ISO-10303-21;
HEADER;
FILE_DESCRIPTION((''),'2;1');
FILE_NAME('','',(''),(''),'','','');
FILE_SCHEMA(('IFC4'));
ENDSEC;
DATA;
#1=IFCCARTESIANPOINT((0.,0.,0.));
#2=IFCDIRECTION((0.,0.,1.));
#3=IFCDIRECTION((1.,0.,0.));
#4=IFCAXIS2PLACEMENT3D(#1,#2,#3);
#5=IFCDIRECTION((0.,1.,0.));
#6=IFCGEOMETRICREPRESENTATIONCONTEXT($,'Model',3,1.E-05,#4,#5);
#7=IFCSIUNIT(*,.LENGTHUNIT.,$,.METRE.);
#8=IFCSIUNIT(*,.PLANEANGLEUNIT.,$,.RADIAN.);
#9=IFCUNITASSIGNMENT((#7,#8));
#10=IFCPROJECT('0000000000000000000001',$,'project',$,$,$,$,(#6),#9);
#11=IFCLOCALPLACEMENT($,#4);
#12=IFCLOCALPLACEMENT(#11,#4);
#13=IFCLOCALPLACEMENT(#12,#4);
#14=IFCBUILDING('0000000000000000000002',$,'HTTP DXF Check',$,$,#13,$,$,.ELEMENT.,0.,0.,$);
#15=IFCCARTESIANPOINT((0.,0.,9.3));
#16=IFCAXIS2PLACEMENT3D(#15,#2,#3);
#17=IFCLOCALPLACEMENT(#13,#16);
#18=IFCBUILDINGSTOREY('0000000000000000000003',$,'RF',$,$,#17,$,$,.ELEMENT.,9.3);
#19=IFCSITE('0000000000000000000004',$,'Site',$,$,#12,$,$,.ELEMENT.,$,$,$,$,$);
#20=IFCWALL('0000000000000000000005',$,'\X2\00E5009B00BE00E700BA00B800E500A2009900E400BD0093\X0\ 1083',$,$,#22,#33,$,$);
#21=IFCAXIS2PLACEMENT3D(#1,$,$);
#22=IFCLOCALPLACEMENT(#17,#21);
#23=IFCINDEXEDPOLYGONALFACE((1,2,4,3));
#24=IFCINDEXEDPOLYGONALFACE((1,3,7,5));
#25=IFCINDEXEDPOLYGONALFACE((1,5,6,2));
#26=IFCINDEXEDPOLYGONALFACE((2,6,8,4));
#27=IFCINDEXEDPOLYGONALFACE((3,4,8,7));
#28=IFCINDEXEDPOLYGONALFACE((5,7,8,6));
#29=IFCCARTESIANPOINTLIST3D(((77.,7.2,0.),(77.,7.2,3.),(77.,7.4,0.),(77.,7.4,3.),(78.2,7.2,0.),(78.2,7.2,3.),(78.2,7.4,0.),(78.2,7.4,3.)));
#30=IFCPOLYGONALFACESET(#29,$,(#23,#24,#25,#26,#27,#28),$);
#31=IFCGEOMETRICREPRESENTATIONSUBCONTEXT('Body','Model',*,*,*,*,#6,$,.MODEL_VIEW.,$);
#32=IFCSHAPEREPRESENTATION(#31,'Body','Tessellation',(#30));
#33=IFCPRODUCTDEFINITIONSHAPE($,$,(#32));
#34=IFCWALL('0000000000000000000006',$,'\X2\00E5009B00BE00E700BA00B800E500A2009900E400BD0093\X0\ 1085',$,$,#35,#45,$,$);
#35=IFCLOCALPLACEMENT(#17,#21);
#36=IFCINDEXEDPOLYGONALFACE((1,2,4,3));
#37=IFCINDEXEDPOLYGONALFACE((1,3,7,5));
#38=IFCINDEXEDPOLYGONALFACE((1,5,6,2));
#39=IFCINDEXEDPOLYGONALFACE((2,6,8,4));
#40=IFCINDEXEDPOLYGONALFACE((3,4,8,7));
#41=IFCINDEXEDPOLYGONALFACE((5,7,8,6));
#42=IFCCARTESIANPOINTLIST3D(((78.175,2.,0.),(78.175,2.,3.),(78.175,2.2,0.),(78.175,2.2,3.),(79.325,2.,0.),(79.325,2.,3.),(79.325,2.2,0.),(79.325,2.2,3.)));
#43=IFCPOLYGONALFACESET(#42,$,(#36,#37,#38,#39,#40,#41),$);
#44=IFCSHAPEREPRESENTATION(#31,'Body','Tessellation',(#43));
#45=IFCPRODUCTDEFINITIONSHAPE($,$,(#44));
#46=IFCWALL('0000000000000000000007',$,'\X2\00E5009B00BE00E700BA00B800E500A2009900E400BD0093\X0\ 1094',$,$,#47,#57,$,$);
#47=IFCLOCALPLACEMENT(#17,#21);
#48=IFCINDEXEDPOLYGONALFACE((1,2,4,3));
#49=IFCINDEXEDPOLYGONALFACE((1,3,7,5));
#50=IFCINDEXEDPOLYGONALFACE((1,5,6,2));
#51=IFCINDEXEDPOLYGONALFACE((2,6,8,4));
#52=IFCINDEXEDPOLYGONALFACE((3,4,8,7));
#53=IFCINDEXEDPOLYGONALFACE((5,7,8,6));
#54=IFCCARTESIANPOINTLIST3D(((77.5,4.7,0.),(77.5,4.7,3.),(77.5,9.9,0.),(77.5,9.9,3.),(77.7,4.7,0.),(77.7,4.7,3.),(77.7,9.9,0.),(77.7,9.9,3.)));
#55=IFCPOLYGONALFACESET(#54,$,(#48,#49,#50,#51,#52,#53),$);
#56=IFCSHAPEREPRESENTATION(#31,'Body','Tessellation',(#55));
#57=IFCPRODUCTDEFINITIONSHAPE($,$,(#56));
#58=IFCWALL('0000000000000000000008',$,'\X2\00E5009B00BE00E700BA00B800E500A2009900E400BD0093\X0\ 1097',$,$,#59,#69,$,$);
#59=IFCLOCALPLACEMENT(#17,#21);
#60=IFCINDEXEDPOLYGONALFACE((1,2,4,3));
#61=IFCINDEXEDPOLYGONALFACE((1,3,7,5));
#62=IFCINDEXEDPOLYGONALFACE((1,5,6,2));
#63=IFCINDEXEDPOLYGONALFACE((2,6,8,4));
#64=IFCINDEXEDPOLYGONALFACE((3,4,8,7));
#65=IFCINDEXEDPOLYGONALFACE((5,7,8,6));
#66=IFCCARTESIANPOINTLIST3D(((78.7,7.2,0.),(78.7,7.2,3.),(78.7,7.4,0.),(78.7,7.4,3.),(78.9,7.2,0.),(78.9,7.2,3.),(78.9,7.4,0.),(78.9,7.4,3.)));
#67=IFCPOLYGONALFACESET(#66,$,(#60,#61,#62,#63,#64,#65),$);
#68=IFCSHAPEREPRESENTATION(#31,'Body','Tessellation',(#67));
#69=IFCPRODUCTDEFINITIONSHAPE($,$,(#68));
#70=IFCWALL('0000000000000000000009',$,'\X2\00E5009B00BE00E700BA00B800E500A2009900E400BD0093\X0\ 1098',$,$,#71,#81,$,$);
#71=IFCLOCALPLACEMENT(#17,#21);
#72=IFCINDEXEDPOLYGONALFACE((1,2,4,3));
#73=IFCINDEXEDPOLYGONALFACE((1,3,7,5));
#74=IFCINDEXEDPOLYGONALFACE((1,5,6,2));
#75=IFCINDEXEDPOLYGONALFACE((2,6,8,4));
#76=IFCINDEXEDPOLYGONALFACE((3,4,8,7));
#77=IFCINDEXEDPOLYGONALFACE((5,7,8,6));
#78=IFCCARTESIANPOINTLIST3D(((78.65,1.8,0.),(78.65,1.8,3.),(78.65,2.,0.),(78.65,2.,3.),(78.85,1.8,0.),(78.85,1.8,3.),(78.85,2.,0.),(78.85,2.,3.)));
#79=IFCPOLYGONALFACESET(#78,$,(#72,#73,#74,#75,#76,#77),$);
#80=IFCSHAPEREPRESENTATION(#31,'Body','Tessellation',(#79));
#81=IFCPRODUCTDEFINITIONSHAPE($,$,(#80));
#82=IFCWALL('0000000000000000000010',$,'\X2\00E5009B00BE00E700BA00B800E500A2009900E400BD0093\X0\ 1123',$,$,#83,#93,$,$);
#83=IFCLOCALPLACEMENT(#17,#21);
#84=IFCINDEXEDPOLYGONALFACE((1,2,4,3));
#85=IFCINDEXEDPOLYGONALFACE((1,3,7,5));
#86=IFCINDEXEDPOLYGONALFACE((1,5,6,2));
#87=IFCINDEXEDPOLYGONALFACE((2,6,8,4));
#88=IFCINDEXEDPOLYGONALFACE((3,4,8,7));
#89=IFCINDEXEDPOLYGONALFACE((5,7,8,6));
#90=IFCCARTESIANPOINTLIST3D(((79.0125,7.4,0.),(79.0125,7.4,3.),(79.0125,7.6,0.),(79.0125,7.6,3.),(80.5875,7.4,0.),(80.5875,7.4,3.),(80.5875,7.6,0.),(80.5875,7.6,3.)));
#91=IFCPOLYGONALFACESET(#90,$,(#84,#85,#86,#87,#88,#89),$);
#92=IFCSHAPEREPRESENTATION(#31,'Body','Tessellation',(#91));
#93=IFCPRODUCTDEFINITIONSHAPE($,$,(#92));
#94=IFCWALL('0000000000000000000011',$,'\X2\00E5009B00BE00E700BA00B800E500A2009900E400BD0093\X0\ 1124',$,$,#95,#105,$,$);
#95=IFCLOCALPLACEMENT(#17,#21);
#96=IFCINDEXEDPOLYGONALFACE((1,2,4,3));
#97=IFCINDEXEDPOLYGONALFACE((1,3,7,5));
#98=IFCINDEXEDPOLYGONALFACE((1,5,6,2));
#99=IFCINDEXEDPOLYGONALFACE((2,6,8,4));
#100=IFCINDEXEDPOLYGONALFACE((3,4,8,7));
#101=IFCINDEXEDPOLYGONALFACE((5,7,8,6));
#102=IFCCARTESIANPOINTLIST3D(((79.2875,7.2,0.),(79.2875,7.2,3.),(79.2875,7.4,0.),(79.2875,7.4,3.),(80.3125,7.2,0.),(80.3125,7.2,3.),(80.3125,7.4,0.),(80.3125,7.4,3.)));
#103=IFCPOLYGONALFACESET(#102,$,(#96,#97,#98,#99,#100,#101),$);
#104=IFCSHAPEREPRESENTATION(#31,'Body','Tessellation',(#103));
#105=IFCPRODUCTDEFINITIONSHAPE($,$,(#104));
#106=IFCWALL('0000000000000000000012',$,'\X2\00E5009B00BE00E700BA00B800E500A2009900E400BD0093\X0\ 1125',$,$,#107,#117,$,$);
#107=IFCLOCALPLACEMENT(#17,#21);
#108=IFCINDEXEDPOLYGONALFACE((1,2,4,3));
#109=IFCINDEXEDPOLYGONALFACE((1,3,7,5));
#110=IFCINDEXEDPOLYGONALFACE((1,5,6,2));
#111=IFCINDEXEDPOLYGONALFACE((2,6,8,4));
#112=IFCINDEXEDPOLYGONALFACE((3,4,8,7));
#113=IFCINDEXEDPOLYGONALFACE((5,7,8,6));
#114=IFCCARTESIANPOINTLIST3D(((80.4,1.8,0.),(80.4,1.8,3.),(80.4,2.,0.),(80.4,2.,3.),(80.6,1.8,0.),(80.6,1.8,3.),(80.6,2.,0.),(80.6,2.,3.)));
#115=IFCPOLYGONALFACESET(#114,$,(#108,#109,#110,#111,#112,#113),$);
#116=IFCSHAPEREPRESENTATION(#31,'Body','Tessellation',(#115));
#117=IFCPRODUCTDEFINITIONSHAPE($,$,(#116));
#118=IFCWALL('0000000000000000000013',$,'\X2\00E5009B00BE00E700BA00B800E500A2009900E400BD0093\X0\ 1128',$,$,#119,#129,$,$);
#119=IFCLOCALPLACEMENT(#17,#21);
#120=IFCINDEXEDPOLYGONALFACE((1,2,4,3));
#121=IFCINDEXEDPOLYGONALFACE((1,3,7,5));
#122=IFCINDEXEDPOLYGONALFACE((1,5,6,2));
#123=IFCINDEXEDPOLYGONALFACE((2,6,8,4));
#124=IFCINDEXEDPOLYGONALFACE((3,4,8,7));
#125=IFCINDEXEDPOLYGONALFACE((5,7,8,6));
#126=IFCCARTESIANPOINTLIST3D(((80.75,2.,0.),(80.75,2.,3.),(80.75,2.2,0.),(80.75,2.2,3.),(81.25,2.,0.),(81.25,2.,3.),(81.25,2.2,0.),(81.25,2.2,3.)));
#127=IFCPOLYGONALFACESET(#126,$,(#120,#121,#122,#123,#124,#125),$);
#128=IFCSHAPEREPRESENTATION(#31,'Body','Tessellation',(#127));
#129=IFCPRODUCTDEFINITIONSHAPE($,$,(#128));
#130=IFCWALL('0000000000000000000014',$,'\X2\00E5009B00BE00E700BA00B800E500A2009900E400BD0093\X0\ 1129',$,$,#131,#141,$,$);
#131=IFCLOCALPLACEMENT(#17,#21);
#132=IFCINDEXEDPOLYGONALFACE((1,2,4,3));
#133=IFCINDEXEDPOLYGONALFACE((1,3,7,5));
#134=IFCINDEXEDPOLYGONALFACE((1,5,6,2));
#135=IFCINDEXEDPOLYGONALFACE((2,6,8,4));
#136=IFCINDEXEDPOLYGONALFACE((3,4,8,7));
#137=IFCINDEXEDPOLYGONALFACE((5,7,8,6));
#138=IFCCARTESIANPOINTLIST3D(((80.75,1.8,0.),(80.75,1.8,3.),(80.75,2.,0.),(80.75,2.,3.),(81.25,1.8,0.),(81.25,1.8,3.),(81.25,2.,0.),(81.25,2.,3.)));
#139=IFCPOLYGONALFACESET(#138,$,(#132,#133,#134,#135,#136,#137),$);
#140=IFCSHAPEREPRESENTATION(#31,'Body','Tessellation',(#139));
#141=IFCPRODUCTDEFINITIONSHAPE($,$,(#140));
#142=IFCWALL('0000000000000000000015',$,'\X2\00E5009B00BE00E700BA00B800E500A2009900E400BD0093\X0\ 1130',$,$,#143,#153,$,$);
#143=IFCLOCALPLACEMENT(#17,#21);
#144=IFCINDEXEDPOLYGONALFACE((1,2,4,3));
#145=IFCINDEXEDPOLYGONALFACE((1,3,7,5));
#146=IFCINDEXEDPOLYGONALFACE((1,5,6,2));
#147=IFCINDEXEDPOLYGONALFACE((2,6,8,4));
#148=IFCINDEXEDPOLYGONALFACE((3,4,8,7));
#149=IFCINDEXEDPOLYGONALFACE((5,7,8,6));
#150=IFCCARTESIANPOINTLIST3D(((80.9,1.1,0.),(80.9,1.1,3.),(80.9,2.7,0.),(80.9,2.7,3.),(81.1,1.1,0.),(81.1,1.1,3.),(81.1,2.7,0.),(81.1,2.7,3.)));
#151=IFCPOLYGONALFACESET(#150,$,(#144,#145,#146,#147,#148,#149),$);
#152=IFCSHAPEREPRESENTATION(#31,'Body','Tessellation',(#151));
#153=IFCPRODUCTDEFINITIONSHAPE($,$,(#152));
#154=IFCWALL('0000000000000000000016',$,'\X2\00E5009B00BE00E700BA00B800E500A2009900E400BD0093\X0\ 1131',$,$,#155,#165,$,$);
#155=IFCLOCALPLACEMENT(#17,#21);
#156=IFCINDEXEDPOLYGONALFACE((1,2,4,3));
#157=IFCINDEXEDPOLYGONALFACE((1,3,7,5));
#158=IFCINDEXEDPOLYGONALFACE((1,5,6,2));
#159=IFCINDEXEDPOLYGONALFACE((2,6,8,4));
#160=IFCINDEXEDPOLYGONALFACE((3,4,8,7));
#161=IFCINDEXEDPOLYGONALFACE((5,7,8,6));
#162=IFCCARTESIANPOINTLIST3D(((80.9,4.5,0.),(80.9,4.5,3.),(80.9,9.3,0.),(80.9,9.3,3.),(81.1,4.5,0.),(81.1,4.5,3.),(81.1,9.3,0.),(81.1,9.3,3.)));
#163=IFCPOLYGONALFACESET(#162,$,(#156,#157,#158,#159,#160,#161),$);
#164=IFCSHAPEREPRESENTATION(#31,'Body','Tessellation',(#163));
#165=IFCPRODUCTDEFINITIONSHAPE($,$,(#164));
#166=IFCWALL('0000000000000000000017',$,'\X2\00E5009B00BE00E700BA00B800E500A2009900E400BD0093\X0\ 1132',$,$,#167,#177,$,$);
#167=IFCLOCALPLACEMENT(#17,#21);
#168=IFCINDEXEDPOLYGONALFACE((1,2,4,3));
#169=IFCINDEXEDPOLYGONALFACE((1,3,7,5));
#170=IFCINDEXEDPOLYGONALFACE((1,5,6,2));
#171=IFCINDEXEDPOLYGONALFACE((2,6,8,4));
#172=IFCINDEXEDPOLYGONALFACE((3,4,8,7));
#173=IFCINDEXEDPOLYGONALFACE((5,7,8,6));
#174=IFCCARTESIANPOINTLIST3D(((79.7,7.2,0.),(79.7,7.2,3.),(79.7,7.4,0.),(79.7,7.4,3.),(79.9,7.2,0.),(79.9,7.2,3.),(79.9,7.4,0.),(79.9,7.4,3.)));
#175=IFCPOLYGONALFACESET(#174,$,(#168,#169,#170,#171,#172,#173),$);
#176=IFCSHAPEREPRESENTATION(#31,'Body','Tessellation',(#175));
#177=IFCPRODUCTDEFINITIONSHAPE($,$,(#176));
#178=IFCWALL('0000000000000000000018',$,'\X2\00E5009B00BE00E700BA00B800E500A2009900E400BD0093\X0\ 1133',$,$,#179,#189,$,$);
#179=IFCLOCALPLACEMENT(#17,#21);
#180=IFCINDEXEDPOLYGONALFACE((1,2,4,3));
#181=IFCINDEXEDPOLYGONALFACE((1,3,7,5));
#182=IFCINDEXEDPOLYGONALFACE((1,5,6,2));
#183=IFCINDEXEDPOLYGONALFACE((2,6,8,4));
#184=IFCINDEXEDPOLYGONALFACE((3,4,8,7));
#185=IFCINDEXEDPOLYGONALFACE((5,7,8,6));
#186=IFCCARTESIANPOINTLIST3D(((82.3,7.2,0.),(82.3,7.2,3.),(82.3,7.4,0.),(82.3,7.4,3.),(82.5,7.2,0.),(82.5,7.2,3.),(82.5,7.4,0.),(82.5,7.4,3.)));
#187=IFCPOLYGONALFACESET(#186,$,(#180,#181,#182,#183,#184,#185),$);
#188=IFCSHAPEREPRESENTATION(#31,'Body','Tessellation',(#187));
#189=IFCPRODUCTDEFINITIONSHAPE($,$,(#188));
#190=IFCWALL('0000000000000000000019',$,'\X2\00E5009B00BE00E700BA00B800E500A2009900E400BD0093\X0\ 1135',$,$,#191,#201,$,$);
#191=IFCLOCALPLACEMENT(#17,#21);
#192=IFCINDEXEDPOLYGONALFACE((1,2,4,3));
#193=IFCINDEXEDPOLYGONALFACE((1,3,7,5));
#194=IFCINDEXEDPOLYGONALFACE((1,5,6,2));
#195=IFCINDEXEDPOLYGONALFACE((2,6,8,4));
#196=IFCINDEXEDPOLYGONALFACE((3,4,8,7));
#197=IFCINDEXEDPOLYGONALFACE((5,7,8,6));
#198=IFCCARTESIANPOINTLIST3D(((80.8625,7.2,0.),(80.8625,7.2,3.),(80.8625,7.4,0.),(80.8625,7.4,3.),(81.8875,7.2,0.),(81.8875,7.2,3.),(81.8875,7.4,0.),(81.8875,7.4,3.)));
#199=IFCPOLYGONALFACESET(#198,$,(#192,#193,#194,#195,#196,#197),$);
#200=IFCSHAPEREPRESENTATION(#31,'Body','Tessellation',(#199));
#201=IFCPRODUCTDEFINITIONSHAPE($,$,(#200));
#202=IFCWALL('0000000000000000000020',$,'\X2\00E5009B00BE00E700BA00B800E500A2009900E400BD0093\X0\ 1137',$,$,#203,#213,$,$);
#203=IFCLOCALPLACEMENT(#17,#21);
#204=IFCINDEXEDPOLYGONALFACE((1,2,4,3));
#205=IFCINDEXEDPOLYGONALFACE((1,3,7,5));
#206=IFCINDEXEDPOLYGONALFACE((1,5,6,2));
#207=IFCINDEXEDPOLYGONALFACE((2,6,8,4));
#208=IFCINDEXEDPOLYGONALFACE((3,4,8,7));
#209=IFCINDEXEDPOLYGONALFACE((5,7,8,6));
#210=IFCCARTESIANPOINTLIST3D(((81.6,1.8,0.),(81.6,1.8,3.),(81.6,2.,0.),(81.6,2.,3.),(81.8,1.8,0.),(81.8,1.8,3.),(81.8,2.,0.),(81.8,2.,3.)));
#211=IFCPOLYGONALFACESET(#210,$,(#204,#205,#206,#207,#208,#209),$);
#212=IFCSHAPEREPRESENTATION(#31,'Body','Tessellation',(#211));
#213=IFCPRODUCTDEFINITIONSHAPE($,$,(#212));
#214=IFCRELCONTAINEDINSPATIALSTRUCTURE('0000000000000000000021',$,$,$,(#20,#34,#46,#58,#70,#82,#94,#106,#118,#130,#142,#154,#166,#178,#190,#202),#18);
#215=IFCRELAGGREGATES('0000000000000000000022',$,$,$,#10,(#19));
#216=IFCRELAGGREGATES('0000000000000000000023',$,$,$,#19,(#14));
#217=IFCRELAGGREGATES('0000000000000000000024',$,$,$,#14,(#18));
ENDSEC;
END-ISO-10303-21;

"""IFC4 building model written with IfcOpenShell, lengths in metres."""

from ifc_helpers import new_model, si_unit, direction, frame, frame_2d, origin_with_axes, place, context, subcontext, project, spatial, rectangle, extrude, element, save


model = new_model("IFC4")

# Units and contexts
model_context = context("Model", 3, precision=1e-05, world=origin_with_axes(), true_north=direction((0.0, 1.0, 0.0)))
body_context = subcontext(model_context, "Body", "Model", "MODEL_VIEW")
ifc_project = project(units=[si_unit("LENGTHUNIT", "METRE"), si_unit("PLANEANGLEUNIT", "RADIAN")], contexts=[model_context])

# Site, building, storey
placement = place(None, origin_with_axes())
site_placement = place(placement, origin_with_axes())
site = spatial("IfcSite", under=ifc_project, at=site_placement, Name="Site", CompositionType="ELEMENT")
building_placement = place(site_placement, origin_with_axes())
building = spatial("IfcBuilding", under=site, at=building_placement, Name="HTTP DXF Check", CompositionType="ELEMENT", ElevationOfRefHeight=0.0, ElevationOfTerrain=0.0)
storey_placement = place(building_placement, frame((0.0, 0.0, 9.3), z_axis=(0.0, 0.0, 1.0), x_axis=(1.0, 0.0, 0.0)))
storey = spatial("IfcBuildingStorey", under=building, at=storey_placement, Name="RF", CompositionType="ELEMENT", Elevation=9.3)

# Walls
wall_1_placement = place(storey_placement, frame((77.6, 7.3, 0.0), z_axis=(0.0, 0.0, 1.0), x_axis=(1.0, 0.0, 0.0)))
element("IfcWall", 1, at=wall_1_placement, inside=storey, Name="å\u009b¾çº¸å¢\u0099ä½\u0093 1083", context=body_context, shape_type="SweptSolid", body=[
    extrude(rectangle(XDim=1.2, YDim=0.2, at=frame_2d((0.0, 0.0), x_axis=(1.0, 0.0, 0.0))), frame((0.0, 0.0, 0.0), z_axis=(0.0, 0.0, 1.0)), (0.0, 0.0, 1.0), 3.0),
])
wall_2_placement = place(storey_placement, frame((78.75, 2.1, 0.0), z_axis=(0.0, 0.0, 1.0), x_axis=(-1.0, 0.0, 0.0)))
element("IfcWall", 2, at=wall_2_placement, inside=storey, Name="å\u009b¾çº¸å¢\u0099ä½\u0093 1085", context=body_context, shape_type="SweptSolid", body=[
    extrude(rectangle(XDim=1.15, YDim=0.2, at=frame_2d((0.0, 0.0), x_axis=(1.0, 0.0, 0.0))), frame((0.0, 0.0, 0.0), z_axis=(0.0, 0.0, 1.0)), (0.0, 0.0, 1.0), 3.0),
])
wall_3_placement = place(storey_placement, frame((77.6, 7.3, 0.0), z_axis=(0.0, 0.0, 1.0), x_axis=(0.0, -1.0, 0.0)))
element("IfcWall", 3, at=wall_3_placement, inside=storey, Name="å\u009b¾çº¸å¢\u0099ä½\u0093 1094", context=body_context, shape_type="SweptSolid", body=[
    extrude(rectangle(XDim=5.2, YDim=0.2, at=frame_2d((0.0, 0.0), x_axis=(1.0, 0.0, 0.0))), frame((0.0, 0.0, 0.0), z_axis=(0.0, 0.0, 1.0)), (0.0, 0.0, 1.0), 3.0),
])
for number, where, z_axis, x_axis, name in (
    (4, (78.8, 7.3, 0.0), (0.0, 0.0, 1.0), (0.0, 1.0, 0.0), "å\u009b¾çº¸å¢\u0099ä½\u0093 1097"),
    (5, (78.75, 1.9, 0.0), (0.0, 0.0, 1.0), (0.0, 1.0, 0.0), "å\u009b¾çº¸å¢\u0099ä½\u0093 1098"),
):
    element("IfcWall", number, at=place(storey_placement, frame(where, z_axis=z_axis, x_axis=x_axis)), inside=storey, Name=name, context=body_context, shape_type="SweptSolid", body=[
        extrude(rectangle(XDim=0.2, YDim=0.2, at=frame_2d((0.0, 0.0), x_axis=(1.0, 0.0, 0.0))), frame((0.0, 0.0, 0.0), z_axis=(0.0, 0.0, 1.0)), (0.0, 0.0, 1.0), 3.0),
    ])
wall_4_placement = place(storey_placement, frame((79.8, 7.5, 0.0), z_axis=(0.0, 0.0, 1.0), x_axis=(1.0, 0.0, 0.0)))
element("IfcWall", 6, at=wall_4_placement, inside=storey, Name="å\u009b¾çº¸å¢\u0099ä½\u0093 1123", context=body_context, shape_type="SweptSolid", body=[
    extrude(rectangle(XDim=1.575, YDim=0.2, at=frame_2d((0.0, 0.0), x_axis=(1.0, 0.0, 0.0))), frame((0.0, 0.0, 0.0), z_axis=(0.0, 0.0, 1.0)), (0.0, 0.0, 1.0), 3.0),
])
wall_5_placement = place(storey_placement, frame((79.8, 7.3, 0.0), z_axis=(0.0, 0.0, 1.0), x_axis=(1.0, 0.0, 0.0)))
element("IfcWall", 7, at=wall_5_placement, inside=storey, Name="å\u009b¾çº¸å¢\u0099ä½\u0093 1124", context=body_context, shape_type="SweptSolid", body=[
    extrude(rectangle(XDim=1.025, YDim=0.2, at=frame_2d((0.0, 0.0), x_axis=(1.0, 0.0, 0.0))), frame((0.0, 0.0, 0.0), z_axis=(0.0, 0.0, 1.0)), (0.0, 0.0, 1.0), 3.0),
])
wall_6_placement = place(storey_placement, frame((80.5, 1.9, 0.0), z_axis=(0.0, 0.0, 1.0), x_axis=(0.0, 1.0, 0.0)))
element("IfcWall", 8, at=wall_6_placement, inside=storey, Name="å\u009b¾çº¸å¢\u0099ä½\u0093 1125", context=body_context, shape_type="SweptSolid", body=[
    extrude(rectangle(XDim=0.2, YDim=0.2, at=frame_2d((0.0, 0.0), x_axis=(1.0, 0.0, 0.0))), frame((0.0, 0.0, 0.0), z_axis=(0.0, 0.0, 1.0)), (0.0, 0.0, 1.0), 3.0),
])
for number, where, z_axis, x_axis, name in (
    (9, (81.0, 2.1, 0.0), (0.0, 0.0, 1.0), (-1.0, 0.0, 0.0), "å\u009b¾çº¸å¢\u0099ä½\u0093 1128"),
    (10, (81.0, 1.9, 0.0), (0.0, 0.0, 1.0), (-1.0, 0.0, 0.0), "å\u009b¾çº¸å¢\u0099ä½\u0093 1129"),
):
    element("IfcWall", number, at=place(storey_placement, frame(where, z_axis=z_axis, x_axis=x_axis)), inside=storey, Name=name, context=body_context, shape_type="SweptSolid", body=[
        extrude(rectangle(XDim=0.5, YDim=0.2, at=frame_2d((0.0, 0.0), x_axis=(1.0, 0.0, 0.0))), frame((0.0, 0.0, 0.0), z_axis=(0.0, 0.0, 1.0)), (0.0, 0.0, 1.0), 3.0),
    ])
wall_7_placement = place(storey_placement, frame((81.0, 1.9, 0.0), z_axis=(0.0, 0.0, 1.0), x_axis=(0.0, -1.0, 0.0)))
element("IfcWall", 11, at=wall_7_placement, inside=storey, Name="å\u009b¾çº¸å¢\u0099ä½\u0093 1130", context=body_context, shape_type="SweptSolid", body=[
    extrude(rectangle(XDim=1.6, YDim=0.2, at=frame_2d((0.0, 0.0), x_axis=(1.0, 0.0, 0.0))), frame((0.0, 0.0, 0.0), z_axis=(0.0, 0.0, 1.0)), (0.0, 0.0, 1.0), 3.0),
])
wall_8_placement = place(storey_placement, frame((81.0, 6.9, 0.0), z_axis=(0.0, 0.0, 1.0), x_axis=(0.0, -1.0, 0.0)))
element("IfcWall", 12, at=wall_8_placement, inside=storey, Name="å\u009b¾çº¸å¢\u0099ä½\u0093 1131", context=body_context, shape_type="SweptSolid", body=[
    extrude(rectangle(XDim=4.8, YDim=0.2, at=frame_2d((0.0, 0.0), x_axis=(1.0, 0.0, 0.0))), frame((0.0, 0.0, 0.0), z_axis=(0.0, 0.0, 1.0)), (0.0, 0.0, 1.0), 3.0),
])
for number, where, z_axis, x_axis, name in (
    (13, (79.8, 7.3, 0.0), (0.0, 0.0, 1.0), (0.0, 1.0, 0.0), "å\u009b¾çº¸å¢\u0099ä½\u0093 1132"),
    (14, (82.4, 7.3, 0.0), (0.0, 0.0, 1.0), (0.0, 1.0, 0.0), "å\u009b¾çº¸å¢\u0099ä½\u0093 1133"),
):
    element("IfcWall", number, at=place(storey_placement, frame(where, z_axis=z_axis, x_axis=x_axis)), inside=storey, Name=name, context=body_context, shape_type="SweptSolid", body=[
        extrude(rectangle(XDim=0.2, YDim=0.2, at=frame_2d((0.0, 0.0), x_axis=(1.0, 0.0, 0.0))), frame((0.0, 0.0, 0.0), z_axis=(0.0, 0.0, 1.0)), (0.0, 0.0, 1.0), 3.0),
    ])
wall_9_placement = place(storey_placement, frame((81.375, 7.3, 0.0), z_axis=(0.0, 0.0, 1.0), x_axis=(1.0, 0.0, 0.0)))
element("IfcWall", 15, at=wall_9_placement, inside=storey, Name="å\u009b¾çº¸å¢\u0099ä½\u0093 1135", context=body_context, shape_type="SweptSolid", body=[
    extrude(rectangle(XDim=1.025, YDim=0.2, at=frame_2d((0.0, 0.0), x_axis=(1.0, 0.0, 0.0))), frame((0.0, 0.0, 0.0), z_axis=(0.0, 0.0, 1.0)), (0.0, 0.0, 1.0), 3.0),
])
wall_10_placement = place(storey_placement, frame((81.7, 1.9, 0.0), z_axis=(0.0, 0.0, 1.0), x_axis=(0.0, 1.0, 0.0)))
element("IfcWall", 16, at=wall_10_placement, inside=storey, Name="å\u009b¾çº¸å¢\u0099ä½\u0093 1137", context=body_context, shape_type="SweptSolid", body=[
    extrude(rectangle(XDim=0.2, YDim=0.2, at=frame_2d((0.0, 0.0), x_axis=(1.0, 0.0, 0.0))), frame((0.0, 0.0, 0.0), z_axis=(0.0, 0.0, 1.0)), (0.0, 0.0, 1.0), 3.0),
])

save(model, "model.ifc")
